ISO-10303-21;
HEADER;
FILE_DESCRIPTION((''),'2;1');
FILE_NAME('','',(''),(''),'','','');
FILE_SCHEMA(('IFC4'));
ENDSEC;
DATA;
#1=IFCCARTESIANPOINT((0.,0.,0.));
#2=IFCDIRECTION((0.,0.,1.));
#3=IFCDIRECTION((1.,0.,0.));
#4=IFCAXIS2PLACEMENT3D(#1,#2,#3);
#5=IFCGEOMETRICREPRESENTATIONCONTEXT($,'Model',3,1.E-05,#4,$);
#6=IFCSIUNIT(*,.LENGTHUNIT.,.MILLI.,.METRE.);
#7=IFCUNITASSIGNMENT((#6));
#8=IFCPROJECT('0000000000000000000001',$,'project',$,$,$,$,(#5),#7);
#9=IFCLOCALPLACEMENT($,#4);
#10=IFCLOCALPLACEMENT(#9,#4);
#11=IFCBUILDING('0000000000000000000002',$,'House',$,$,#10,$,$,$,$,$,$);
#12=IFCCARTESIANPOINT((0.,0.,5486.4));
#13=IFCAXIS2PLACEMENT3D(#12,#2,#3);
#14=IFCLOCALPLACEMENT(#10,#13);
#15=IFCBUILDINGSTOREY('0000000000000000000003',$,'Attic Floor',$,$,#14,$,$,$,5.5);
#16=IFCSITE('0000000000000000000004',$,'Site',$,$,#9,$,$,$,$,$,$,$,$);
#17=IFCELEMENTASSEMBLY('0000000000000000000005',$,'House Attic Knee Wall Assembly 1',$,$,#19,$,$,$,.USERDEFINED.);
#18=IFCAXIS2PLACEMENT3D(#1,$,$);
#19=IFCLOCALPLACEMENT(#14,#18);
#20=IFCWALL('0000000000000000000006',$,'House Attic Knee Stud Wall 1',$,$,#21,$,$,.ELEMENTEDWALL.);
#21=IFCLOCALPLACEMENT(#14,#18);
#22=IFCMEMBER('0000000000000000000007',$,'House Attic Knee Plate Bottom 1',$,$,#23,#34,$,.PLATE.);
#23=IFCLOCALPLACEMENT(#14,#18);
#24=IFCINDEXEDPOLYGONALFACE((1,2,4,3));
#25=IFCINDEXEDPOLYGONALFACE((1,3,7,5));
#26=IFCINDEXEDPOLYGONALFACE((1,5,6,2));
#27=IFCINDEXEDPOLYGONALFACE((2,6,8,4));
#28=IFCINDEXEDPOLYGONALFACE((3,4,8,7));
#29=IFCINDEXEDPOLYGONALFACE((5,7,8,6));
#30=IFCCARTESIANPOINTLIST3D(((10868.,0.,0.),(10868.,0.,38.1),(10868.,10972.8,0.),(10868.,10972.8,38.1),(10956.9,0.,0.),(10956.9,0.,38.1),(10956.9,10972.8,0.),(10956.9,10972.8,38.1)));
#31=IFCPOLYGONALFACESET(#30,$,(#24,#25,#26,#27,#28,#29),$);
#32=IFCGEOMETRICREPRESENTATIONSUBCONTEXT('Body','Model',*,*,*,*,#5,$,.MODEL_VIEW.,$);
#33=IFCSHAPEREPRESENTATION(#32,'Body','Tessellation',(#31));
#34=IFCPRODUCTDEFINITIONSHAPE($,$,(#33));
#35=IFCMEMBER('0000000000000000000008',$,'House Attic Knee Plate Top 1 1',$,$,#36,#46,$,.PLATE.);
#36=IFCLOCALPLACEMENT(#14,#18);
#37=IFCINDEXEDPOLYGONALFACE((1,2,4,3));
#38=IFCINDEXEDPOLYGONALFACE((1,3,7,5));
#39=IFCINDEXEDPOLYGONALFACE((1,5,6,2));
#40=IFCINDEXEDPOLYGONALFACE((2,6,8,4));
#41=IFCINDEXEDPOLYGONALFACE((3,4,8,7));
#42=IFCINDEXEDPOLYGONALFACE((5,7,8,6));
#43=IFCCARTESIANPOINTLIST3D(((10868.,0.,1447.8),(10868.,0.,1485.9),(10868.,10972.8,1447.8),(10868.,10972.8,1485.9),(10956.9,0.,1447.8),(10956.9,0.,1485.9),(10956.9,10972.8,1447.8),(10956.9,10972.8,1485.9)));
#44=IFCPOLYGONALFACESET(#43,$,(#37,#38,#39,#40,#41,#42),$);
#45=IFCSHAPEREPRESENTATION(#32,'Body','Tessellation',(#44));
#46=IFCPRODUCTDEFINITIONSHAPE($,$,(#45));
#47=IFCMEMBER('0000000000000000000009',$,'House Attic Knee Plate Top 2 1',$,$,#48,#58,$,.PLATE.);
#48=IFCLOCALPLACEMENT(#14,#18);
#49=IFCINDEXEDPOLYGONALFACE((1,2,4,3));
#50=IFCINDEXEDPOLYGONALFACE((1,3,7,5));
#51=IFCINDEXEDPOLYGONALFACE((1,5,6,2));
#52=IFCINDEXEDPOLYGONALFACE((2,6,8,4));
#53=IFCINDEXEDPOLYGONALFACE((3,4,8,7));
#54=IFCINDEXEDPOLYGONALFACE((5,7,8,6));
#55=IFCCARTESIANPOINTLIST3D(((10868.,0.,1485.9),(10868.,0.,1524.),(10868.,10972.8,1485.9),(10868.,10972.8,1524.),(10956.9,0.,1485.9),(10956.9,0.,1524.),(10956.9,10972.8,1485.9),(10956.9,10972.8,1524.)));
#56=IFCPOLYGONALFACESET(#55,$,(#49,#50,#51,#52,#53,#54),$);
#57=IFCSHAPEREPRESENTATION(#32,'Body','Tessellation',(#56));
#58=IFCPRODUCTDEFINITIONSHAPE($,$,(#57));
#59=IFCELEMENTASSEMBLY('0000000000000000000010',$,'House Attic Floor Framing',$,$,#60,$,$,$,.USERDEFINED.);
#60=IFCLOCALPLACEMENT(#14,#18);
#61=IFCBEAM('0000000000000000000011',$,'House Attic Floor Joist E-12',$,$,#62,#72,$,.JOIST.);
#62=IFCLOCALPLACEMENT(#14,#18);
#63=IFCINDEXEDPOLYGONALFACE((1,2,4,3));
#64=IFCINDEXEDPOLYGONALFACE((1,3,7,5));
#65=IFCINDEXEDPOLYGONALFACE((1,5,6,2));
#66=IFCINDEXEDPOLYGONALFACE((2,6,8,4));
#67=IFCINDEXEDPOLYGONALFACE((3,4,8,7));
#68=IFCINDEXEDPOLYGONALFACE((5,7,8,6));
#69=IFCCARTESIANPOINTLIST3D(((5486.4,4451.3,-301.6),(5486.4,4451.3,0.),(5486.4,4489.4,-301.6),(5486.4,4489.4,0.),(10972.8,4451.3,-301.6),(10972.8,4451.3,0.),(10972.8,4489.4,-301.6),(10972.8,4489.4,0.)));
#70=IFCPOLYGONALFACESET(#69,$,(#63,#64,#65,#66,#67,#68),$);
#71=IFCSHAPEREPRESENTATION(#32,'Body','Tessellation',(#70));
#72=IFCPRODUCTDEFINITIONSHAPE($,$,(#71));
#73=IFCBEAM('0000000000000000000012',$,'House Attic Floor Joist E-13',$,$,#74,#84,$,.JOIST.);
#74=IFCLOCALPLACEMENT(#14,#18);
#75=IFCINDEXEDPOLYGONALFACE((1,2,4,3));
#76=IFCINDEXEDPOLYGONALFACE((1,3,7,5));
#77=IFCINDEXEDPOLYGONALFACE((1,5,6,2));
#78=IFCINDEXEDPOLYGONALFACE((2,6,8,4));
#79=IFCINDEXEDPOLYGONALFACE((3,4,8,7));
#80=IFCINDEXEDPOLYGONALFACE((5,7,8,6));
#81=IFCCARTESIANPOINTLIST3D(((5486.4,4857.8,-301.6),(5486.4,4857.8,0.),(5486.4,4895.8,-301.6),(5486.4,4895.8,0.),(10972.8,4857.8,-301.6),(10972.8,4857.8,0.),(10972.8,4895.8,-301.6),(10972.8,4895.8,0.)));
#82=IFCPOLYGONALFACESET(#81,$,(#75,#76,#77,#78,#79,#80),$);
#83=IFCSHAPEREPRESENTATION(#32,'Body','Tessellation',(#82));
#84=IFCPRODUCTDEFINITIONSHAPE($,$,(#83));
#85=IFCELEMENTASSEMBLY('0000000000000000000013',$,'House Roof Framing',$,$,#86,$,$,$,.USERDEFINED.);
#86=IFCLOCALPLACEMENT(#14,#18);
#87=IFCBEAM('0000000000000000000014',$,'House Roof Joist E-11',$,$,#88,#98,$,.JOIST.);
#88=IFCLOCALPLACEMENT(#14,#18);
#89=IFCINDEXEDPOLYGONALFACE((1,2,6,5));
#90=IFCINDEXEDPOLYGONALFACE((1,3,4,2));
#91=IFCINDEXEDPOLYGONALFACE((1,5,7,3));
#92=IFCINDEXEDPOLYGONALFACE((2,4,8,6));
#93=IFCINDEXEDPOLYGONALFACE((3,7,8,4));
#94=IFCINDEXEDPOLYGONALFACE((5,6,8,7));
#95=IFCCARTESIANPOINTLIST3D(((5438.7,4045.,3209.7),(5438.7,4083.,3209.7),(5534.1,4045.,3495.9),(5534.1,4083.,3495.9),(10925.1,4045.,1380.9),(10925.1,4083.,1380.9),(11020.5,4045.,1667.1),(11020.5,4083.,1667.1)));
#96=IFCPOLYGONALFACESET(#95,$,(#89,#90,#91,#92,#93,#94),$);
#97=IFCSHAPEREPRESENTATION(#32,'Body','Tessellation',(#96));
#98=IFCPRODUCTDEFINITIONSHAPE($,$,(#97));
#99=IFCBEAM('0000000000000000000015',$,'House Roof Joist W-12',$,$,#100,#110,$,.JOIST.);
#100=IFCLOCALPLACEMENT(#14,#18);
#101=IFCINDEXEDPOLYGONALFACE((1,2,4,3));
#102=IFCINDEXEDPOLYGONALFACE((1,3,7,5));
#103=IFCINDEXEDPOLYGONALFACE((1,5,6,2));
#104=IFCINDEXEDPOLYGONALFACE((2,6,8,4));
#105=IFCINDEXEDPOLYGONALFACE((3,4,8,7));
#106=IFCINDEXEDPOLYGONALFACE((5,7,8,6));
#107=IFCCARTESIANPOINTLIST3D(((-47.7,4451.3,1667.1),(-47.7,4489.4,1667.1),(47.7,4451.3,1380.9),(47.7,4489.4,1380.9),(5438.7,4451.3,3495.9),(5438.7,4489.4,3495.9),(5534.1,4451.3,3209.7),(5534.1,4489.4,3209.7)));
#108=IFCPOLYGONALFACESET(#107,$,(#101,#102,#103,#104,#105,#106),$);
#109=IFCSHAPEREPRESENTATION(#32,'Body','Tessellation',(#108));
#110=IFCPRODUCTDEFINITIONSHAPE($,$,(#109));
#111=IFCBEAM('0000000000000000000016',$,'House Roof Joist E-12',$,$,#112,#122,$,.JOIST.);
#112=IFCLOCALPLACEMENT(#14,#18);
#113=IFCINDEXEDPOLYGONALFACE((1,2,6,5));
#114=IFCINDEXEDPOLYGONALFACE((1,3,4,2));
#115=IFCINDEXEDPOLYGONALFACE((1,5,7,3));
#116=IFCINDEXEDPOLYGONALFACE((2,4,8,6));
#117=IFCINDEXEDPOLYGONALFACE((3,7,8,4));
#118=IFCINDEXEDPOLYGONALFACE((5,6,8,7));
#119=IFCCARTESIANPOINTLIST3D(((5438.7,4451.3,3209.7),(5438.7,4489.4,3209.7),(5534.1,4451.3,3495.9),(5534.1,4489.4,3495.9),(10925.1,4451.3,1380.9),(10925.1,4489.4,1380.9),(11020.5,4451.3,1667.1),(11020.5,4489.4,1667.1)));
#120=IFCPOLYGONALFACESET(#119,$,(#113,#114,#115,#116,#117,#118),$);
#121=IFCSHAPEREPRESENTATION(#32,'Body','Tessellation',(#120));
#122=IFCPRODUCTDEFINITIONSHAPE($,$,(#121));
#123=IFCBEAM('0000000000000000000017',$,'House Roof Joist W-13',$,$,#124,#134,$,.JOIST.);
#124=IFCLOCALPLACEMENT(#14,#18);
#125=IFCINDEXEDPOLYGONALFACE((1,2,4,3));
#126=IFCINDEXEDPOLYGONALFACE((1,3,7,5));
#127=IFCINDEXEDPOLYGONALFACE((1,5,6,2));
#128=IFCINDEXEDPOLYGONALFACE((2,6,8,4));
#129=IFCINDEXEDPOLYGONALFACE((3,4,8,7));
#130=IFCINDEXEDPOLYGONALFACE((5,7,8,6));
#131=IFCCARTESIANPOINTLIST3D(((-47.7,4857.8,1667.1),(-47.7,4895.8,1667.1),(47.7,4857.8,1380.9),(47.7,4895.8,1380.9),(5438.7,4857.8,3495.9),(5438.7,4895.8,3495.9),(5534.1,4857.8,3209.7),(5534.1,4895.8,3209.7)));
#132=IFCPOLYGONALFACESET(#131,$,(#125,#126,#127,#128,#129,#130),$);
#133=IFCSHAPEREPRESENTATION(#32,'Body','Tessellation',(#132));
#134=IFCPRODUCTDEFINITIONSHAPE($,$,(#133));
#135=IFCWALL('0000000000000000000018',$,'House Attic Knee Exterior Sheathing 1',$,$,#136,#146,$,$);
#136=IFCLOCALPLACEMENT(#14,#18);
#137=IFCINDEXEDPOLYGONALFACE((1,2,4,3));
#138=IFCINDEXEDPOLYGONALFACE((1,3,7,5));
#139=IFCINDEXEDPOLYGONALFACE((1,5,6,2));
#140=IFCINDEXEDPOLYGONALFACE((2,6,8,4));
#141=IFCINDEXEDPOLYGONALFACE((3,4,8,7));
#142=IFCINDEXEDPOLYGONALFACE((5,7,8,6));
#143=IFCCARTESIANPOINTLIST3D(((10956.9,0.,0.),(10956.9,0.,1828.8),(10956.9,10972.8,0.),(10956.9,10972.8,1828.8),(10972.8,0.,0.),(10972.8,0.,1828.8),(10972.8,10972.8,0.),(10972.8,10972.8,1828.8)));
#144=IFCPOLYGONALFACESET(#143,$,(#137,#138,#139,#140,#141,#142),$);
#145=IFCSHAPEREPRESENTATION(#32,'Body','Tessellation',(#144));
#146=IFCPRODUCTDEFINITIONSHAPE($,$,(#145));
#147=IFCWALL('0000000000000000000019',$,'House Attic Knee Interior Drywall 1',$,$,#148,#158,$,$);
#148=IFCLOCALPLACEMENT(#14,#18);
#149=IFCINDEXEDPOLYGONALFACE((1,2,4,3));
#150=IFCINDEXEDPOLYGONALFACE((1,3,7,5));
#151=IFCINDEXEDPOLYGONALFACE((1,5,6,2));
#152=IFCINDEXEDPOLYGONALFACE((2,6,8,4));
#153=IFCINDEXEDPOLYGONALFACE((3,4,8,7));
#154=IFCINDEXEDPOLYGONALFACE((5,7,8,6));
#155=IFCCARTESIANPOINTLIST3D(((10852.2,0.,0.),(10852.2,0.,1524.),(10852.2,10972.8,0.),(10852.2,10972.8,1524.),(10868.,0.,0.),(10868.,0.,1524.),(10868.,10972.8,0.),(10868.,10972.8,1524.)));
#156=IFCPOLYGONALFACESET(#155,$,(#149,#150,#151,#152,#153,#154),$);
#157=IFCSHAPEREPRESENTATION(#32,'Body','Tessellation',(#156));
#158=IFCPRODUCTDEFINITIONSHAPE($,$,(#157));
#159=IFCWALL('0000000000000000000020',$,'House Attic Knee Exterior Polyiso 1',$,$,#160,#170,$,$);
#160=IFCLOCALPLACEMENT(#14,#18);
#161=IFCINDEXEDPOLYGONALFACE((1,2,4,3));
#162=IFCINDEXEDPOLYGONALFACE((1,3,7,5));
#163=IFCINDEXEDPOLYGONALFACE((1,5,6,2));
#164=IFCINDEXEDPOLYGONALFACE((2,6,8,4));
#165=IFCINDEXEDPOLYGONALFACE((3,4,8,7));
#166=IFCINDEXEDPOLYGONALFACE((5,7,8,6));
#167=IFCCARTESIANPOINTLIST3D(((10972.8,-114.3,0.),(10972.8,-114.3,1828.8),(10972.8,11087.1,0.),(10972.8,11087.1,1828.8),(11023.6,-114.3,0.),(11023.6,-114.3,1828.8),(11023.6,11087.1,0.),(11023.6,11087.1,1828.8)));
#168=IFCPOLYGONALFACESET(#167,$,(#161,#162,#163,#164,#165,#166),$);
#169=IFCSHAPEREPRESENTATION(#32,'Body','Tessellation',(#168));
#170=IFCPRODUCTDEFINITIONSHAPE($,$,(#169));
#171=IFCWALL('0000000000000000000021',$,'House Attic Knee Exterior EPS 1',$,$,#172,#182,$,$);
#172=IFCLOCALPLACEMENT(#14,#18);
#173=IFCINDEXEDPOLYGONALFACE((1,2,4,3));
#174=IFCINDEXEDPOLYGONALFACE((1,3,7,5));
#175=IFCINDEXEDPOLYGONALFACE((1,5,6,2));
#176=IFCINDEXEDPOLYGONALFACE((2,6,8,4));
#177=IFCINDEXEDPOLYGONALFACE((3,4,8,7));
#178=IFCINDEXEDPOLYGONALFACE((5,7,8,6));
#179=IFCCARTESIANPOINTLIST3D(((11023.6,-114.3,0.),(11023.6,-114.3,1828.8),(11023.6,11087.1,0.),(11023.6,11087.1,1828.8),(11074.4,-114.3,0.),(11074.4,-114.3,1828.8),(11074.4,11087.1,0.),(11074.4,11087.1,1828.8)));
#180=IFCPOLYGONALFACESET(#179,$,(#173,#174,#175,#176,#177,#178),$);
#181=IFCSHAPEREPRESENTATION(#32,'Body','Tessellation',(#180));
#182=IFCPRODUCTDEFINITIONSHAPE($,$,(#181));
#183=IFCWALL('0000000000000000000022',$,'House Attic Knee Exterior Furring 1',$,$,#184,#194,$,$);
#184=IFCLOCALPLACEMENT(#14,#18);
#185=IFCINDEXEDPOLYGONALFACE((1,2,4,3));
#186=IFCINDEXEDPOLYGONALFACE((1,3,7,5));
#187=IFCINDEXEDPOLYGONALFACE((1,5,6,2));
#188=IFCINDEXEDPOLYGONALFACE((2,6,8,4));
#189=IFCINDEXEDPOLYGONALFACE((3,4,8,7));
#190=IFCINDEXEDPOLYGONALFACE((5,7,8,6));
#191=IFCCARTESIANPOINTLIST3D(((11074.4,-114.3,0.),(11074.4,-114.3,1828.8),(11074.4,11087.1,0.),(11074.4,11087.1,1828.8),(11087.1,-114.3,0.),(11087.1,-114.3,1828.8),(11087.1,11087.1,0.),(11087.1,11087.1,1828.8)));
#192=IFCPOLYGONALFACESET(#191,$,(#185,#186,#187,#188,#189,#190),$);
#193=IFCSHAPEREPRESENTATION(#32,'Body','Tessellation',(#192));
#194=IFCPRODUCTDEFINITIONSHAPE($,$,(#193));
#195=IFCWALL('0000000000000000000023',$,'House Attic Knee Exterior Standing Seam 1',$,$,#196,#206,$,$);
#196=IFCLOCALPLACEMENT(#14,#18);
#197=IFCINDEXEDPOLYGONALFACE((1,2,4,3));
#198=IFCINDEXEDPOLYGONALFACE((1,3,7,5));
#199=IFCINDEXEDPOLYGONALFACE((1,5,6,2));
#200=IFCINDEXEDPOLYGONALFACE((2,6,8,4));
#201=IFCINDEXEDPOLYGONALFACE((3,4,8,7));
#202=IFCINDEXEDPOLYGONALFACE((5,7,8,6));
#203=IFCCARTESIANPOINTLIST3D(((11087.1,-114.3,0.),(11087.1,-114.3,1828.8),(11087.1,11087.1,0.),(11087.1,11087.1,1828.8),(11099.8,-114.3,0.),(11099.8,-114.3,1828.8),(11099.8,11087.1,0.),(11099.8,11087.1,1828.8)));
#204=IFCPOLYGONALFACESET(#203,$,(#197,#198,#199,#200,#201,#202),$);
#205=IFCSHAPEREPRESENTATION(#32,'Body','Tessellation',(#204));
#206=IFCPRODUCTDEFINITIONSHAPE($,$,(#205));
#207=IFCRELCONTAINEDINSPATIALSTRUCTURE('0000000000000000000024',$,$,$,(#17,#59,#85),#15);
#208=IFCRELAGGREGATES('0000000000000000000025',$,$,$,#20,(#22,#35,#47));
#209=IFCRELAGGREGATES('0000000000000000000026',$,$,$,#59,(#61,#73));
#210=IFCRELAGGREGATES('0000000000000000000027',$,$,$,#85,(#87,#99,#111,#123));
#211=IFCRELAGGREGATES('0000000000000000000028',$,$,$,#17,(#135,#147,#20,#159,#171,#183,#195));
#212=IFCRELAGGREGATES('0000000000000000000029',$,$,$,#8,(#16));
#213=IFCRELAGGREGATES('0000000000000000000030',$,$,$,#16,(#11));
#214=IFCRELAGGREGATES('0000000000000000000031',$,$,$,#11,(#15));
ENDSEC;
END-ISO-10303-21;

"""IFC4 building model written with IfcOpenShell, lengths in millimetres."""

from ifc_helpers import new_model, si_unit, frame, origin_with_axes, origin_2d, place, context, subcontext, project, spatial, indexed_curve, rectangle, outline, extrude, element, aggregate, save


model = new_model("IFC4")

# Units and contexts
model_context = context("Model", 3, precision=1e-05, world=origin_with_axes())
body_context = subcontext(model_context, "Body", "Model", "MODEL_VIEW")
ifc_project = project(units=[si_unit("LENGTHUNIT", "METRE", prefix="MILLI")], contexts=[model_context])

# Site, building, storey
site_placement = place(None, origin_with_axes())
site = spatial("IfcSite", under=ifc_project, at=site_placement, Name="Site")
building_placement = place(site_placement, origin_with_axes())
building = spatial("IfcBuilding", under=site, at=building_placement, Name="House")
storey_placement = place(building_placement, frame((0.0, 0.0, 5486.4), z_axis=(0.0, 0.0, 1.0), x_axis=(1.0, 0.0, 0.0)))
storey = spatial("IfcBuildingStorey", under=building, at=storey_placement, Name="Attic Floor", Elevation=5.5)

# Element assembly, wall, members
assembly_1_placement = place(storey_placement, frame((0.0, 0.0, -5486.4), z_axis=(0.0, 0.0, 1.0), x_axis=(1.0, 0.0, 0.0)))
assembly_1 = element("IfcElementAssembly", 1, at=assembly_1_placement, inside=storey, Name="House Attic Knee Wall Assembly 1", PredefinedType="USERDEFINED")
wall_1_placement = place(assembly_1_placement, frame((10972.8, 0.0, 5486.4), z_axis=(0.0, 0.0, 1.0), x_axis=(0.0, 1.0, 0.0)))
wall_1 = element("IfcWall", 2, at=wall_1_placement, Name="House Attic Knee Stud Wall 1", PredefinedType="ELEMENTEDWALL")
member_1_placement = place(wall_1_placement, frame((0.0, 60.3, 19.1), z_axis=(1.0, 0.0, 0.0), x_axis=(0.0, 0.0, 1.0)))
member_1 = element("IfcMember", 3, at=member_1_placement, Name="House Attic Knee Plate Bottom 1", PredefinedType="PLATE", context=body_context, shape_type="SweptSolid", body=[
    extrude(rectangle(XDim=38.1, YDim=88.9, at=origin_2d()), origin_with_axes(), (0.0, 0.0, 1.0), 10972.8),
])
member_2_placement = place(wall_1_placement, frame((0.0, 60.3, 1466.8), z_axis=(1.0, 0.0, 0.0), x_axis=(0.0, 0.0, 1.0)))
member_2 = element("IfcMember", 4, at=member_2_placement, Name="House Attic Knee Plate Top 1 1", PredefinedType="PLATE", context=body_context, shape_type="SweptSolid", body=[
    extrude(rectangle(XDim=38.1, YDim=88.9, at=origin_2d()), origin_with_axes(), (0.0, 0.0, 1.0), 10972.8),
])
member_3_placement = place(wall_1_placement, frame((0.0, 60.3, 1505.0), z_axis=(1.0, 0.0, 0.0), x_axis=(0.0, 0.0, 1.0)))
member_3 = element("IfcMember", 5, at=member_3_placement, Name="House Attic Knee Plate Top 2 1", PredefinedType="PLATE", context=body_context, shape_type="SweptSolid", body=[
    extrude(rectangle(XDim=38.1, YDim=88.9, at=origin_2d()), origin_with_axes(), (0.0, 0.0, 1.0), 10972.8),
])
aggregate(wall_1, [member_1, member_2, member_3])

# Element assemblies, beams
assembly_2_placement = place(storey_placement, frame((0.0, 0.0, -5486.4), z_axis=(0.0, 0.0, 1.0), x_axis=(1.0, 0.0, 0.0)))
assembly_2 = element("IfcElementAssembly", 6, at=assembly_2_placement, inside=storey, Name="House Attic Floor Framing", PredefinedType="USERDEFINED")
beam_1_placement = place(assembly_2_placement, frame((5486.4, 4470.4, 5335.6), z_axis=(1.0, 0.0, 0.0), x_axis=(0.0, 1.0, 0.0)))
beam_1 = element("IfcBeam", 7, at=beam_1_placement, Name="House Attic Floor Joist E-12", PredefinedType="JOIST", context=body_context, shape_type="SweptSolid", body=[
    extrude(rectangle(XDim=38.1, YDim=301.6, at=origin_2d()), origin_with_axes(), (0.0, 0.0, 1.0), 5486.4),
])
beam_2_placement = place(assembly_2_placement, frame((5486.4, 4876.8, 5335.6), z_axis=(1.0, 0.0, 0.0), x_axis=(0.0, 1.0, 0.0)))
beam_2 = element("IfcBeam", 8, at=beam_2_placement, Name="House Attic Floor Joist E-13", PredefinedType="JOIST", context=body_context, shape_type="SweptSolid", body=[
    extrude(rectangle(XDim=38.1, YDim=301.6, at=origin_2d()), origin_with_axes(), (0.0, 0.0, 1.0), 5486.4),
])
aggregate(assembly_2, [beam_1, beam_2])
assembly_3_placement = place(storey_placement, frame((0.0, 0.0, -5486.4), z_axis=(0.0, 0.0, 1.0), x_axis=(1.0, 0.0, 0.0)))
assembly_3 = element("IfcElementAssembly", 9, at=assembly_3_placement, inside=storey, Name="House Roof Framing", PredefinedType="USERDEFINED")
beam_3_placement = place(assembly_3_placement, frame((5486.4, 4064.0, 8839.2), z_axis=(0.948683, 0.0, -0.316228), x_axis=(0.0, 1.0, 0.0)))
beam_3 = element("IfcBeam", 10, at=beam_3_placement, Name="House Roof Joist E-11", PredefinedType="JOIST", context=body_context, shape_type="SweptSolid", body=[
    extrude(rectangle(XDim=38.1, YDim=301.6, at=origin_2d()), origin_with_axes(), (0.0, 0.0, 1.0), 5783.2),
])
beam_4_placement = place(assembly_3_placement, frame((5486.4, 4470.4, 8839.2), z_axis=(-0.948683, 0.0, -0.316228), x_axis=(0.0, 1.0, 0.0)))
beam_4 = element("IfcBeam", 11, at=beam_4_placement, Name="House Roof Joist W-12", PredefinedType="JOIST", context=body_context, shape_type="SweptSolid", body=[
    extrude(rectangle(XDim=38.1, YDim=301.6, at=origin_2d()), origin_with_axes(), (0.0, 0.0, 1.0), 5783.2),
])
beam_5_placement = place(assembly_3_placement, frame((5486.4, 4470.4, 8839.2), z_axis=(0.948683, 0.0, -0.316228), x_axis=(0.0, 1.0, 0.0)))
beam_5 = element("IfcBeam", 12, at=beam_5_placement, Name="House Roof Joist E-12", PredefinedType="JOIST", context=body_context, shape_type="SweptSolid", body=[
    extrude(rectangle(XDim=38.1, YDim=301.6, at=origin_2d()), origin_with_axes(), (0.0, 0.0, 1.0), 5783.2),
])
beam_6_placement = place(assembly_3_placement, frame((5486.4, 4876.8, 8839.2), z_axis=(-0.948683, 0.0, -0.316228), x_axis=(0.0, 1.0, 0.0)))
beam_6 = element("IfcBeam", 13, at=beam_6_placement, Name="House Roof Joist W-13", PredefinedType="JOIST", context=body_context, shape_type="SweptSolid", body=[
    extrude(rectangle(XDim=38.1, YDim=301.6, at=origin_2d()), origin_with_axes(), (0.0, 0.0, 1.0), 5783.2),
])
aggregate(assembly_3, [beam_3, beam_4, beam_5, beam_6])

# Walls
wall_2_placement = place(assembly_1_placement, frame((10972.8, 0.0, 5486.4), z_axis=(0.0, 0.0, 1.0), x_axis=(0.0, 1.0, 0.0)))
wall_2 = element("IfcWall", 14, at=wall_2_placement, Name="House Attic Knee Exterior Sheathing 1", context=body_context, shape_type="SweptSolid", body=[
    extrude(outline(indexed_curve([(0.0, 0.0), (0.0, 15.9), (10972.8, 15.9), (10972.8, 0.0), (0.0, 0.0)], self_intersect=False)), origin_with_axes(), (0.0, 0.0, 1.0), 1828.8),
])
wall_3_placement = place(assembly_1_placement, frame((10972.8, 0.0, 5486.4), z_axis=(0.0, 0.0, 1.0), x_axis=(0.0, 1.0, 0.0)))
wall_3 = element("IfcWall", 15, at=wall_3_placement, Name="House Attic Knee Interior Drywall 1", context=body_context, shape_type="SweptSolid", body=[
    extrude(outline(indexed_curve([(0.0, 0.0), (0.0, 15.9), (10972.8, 15.9), (10972.8, 0.0), (0.0, 0.0)], self_intersect=False)), frame((0.0, 104.8, 0.0), z_axis=(0.0, 0.0, 1.0), x_axis=(1.0, 0.0, 0.0)), (0.0, 0.0, 1.0), 1524.0),
])
wall_4_placement = place(assembly_1_placement, frame((10972.8, -114.3, 5486.4), z_axis=(0.0, 0.0, 1.0), x_axis=(0.0, 1.0, 0.0)))
wall_4 = element("IfcWall", 16, at=wall_4_placement, Name="House Attic Knee Exterior Polyiso 1", context=body_context, shape_type="SweptSolid", body=[
    extrude(outline(indexed_curve([(0.0, 0.0), (0.0, -50.8), (11201.4, -50.8), (11201.4, 0.0), (0.0, 0.0)], self_intersect=False)), origin_with_axes(), (0.0, 0.0, 1.0), 1828.8),
])
wall_5_placement = place(assembly_1_placement, frame((10972.8, -114.3, 5486.4), z_axis=(0.0, 0.0, 1.0), x_axis=(0.0, 1.0, 0.0)))
wall_5 = element("IfcWall", 17, at=wall_5_placement, Name="House Attic Knee Exterior EPS 1", context=body_context, shape_type="SweptSolid", body=[
    extrude(outline(indexed_curve([(0.0, 0.0), (0.0, -50.8), (11201.4, -50.8), (11201.4, 0.0), (0.0, 0.0)], self_intersect=False)), frame((0.0, -50.8, 0.0), z_axis=(0.0, 0.0, 1.0), x_axis=(1.0, 0.0, 0.0)), (0.0, 0.0, 1.0), 1828.8),
])
wall_6_placement = place(assembly_1_placement, frame((10972.8, -114.3, 5486.4), z_axis=(0.0, 0.0, 1.0), x_axis=(0.0, 1.0, 0.0)))
wall_6 = element("IfcWall", 18, at=wall_6_placement, Name="House Attic Knee Exterior Furring 1", context=body_context, shape_type="SweptSolid", body=[
    extrude(outline(indexed_curve([(0.0, 0.0), (0.0, -12.7), (11201.4, -12.7), (11201.4, 0.0), (0.0, 0.0)], self_intersect=False)), frame((0.0, -101.6, 0.0), z_axis=(0.0, 0.0, 1.0), x_axis=(1.0, 0.0, 0.0)), (0.0, 0.0, 1.0), 1828.8),
])
wall_7_placement = place(assembly_1_placement, frame((10972.8, -114.3, 5486.4), z_axis=(0.0, 0.0, 1.0), x_axis=(0.0, 1.0, 0.0)))
wall_7 = element("IfcWall", 19, at=wall_7_placement, Name="House Attic Knee Exterior Standing Seam 1", context=body_context, shape_type="SweptSolid", body=[
    extrude(outline(indexed_curve([(0.0, 0.0), (0.0, -12.7), (11201.4, -12.7), (11201.4, 0.0), (0.0, 0.0)], self_intersect=False)), frame((0.0, -114.3, 0.0), z_axis=(0.0, 0.0, 1.0), x_axis=(1.0, 0.0, 0.0)), (0.0, 0.0, 1.0), 1828.8),
])
aggregate(assembly_1, [wall_2, wall_3, wall_1, wall_4, wall_5, wall_6, wall_7])

save(model, "model.ifc")
